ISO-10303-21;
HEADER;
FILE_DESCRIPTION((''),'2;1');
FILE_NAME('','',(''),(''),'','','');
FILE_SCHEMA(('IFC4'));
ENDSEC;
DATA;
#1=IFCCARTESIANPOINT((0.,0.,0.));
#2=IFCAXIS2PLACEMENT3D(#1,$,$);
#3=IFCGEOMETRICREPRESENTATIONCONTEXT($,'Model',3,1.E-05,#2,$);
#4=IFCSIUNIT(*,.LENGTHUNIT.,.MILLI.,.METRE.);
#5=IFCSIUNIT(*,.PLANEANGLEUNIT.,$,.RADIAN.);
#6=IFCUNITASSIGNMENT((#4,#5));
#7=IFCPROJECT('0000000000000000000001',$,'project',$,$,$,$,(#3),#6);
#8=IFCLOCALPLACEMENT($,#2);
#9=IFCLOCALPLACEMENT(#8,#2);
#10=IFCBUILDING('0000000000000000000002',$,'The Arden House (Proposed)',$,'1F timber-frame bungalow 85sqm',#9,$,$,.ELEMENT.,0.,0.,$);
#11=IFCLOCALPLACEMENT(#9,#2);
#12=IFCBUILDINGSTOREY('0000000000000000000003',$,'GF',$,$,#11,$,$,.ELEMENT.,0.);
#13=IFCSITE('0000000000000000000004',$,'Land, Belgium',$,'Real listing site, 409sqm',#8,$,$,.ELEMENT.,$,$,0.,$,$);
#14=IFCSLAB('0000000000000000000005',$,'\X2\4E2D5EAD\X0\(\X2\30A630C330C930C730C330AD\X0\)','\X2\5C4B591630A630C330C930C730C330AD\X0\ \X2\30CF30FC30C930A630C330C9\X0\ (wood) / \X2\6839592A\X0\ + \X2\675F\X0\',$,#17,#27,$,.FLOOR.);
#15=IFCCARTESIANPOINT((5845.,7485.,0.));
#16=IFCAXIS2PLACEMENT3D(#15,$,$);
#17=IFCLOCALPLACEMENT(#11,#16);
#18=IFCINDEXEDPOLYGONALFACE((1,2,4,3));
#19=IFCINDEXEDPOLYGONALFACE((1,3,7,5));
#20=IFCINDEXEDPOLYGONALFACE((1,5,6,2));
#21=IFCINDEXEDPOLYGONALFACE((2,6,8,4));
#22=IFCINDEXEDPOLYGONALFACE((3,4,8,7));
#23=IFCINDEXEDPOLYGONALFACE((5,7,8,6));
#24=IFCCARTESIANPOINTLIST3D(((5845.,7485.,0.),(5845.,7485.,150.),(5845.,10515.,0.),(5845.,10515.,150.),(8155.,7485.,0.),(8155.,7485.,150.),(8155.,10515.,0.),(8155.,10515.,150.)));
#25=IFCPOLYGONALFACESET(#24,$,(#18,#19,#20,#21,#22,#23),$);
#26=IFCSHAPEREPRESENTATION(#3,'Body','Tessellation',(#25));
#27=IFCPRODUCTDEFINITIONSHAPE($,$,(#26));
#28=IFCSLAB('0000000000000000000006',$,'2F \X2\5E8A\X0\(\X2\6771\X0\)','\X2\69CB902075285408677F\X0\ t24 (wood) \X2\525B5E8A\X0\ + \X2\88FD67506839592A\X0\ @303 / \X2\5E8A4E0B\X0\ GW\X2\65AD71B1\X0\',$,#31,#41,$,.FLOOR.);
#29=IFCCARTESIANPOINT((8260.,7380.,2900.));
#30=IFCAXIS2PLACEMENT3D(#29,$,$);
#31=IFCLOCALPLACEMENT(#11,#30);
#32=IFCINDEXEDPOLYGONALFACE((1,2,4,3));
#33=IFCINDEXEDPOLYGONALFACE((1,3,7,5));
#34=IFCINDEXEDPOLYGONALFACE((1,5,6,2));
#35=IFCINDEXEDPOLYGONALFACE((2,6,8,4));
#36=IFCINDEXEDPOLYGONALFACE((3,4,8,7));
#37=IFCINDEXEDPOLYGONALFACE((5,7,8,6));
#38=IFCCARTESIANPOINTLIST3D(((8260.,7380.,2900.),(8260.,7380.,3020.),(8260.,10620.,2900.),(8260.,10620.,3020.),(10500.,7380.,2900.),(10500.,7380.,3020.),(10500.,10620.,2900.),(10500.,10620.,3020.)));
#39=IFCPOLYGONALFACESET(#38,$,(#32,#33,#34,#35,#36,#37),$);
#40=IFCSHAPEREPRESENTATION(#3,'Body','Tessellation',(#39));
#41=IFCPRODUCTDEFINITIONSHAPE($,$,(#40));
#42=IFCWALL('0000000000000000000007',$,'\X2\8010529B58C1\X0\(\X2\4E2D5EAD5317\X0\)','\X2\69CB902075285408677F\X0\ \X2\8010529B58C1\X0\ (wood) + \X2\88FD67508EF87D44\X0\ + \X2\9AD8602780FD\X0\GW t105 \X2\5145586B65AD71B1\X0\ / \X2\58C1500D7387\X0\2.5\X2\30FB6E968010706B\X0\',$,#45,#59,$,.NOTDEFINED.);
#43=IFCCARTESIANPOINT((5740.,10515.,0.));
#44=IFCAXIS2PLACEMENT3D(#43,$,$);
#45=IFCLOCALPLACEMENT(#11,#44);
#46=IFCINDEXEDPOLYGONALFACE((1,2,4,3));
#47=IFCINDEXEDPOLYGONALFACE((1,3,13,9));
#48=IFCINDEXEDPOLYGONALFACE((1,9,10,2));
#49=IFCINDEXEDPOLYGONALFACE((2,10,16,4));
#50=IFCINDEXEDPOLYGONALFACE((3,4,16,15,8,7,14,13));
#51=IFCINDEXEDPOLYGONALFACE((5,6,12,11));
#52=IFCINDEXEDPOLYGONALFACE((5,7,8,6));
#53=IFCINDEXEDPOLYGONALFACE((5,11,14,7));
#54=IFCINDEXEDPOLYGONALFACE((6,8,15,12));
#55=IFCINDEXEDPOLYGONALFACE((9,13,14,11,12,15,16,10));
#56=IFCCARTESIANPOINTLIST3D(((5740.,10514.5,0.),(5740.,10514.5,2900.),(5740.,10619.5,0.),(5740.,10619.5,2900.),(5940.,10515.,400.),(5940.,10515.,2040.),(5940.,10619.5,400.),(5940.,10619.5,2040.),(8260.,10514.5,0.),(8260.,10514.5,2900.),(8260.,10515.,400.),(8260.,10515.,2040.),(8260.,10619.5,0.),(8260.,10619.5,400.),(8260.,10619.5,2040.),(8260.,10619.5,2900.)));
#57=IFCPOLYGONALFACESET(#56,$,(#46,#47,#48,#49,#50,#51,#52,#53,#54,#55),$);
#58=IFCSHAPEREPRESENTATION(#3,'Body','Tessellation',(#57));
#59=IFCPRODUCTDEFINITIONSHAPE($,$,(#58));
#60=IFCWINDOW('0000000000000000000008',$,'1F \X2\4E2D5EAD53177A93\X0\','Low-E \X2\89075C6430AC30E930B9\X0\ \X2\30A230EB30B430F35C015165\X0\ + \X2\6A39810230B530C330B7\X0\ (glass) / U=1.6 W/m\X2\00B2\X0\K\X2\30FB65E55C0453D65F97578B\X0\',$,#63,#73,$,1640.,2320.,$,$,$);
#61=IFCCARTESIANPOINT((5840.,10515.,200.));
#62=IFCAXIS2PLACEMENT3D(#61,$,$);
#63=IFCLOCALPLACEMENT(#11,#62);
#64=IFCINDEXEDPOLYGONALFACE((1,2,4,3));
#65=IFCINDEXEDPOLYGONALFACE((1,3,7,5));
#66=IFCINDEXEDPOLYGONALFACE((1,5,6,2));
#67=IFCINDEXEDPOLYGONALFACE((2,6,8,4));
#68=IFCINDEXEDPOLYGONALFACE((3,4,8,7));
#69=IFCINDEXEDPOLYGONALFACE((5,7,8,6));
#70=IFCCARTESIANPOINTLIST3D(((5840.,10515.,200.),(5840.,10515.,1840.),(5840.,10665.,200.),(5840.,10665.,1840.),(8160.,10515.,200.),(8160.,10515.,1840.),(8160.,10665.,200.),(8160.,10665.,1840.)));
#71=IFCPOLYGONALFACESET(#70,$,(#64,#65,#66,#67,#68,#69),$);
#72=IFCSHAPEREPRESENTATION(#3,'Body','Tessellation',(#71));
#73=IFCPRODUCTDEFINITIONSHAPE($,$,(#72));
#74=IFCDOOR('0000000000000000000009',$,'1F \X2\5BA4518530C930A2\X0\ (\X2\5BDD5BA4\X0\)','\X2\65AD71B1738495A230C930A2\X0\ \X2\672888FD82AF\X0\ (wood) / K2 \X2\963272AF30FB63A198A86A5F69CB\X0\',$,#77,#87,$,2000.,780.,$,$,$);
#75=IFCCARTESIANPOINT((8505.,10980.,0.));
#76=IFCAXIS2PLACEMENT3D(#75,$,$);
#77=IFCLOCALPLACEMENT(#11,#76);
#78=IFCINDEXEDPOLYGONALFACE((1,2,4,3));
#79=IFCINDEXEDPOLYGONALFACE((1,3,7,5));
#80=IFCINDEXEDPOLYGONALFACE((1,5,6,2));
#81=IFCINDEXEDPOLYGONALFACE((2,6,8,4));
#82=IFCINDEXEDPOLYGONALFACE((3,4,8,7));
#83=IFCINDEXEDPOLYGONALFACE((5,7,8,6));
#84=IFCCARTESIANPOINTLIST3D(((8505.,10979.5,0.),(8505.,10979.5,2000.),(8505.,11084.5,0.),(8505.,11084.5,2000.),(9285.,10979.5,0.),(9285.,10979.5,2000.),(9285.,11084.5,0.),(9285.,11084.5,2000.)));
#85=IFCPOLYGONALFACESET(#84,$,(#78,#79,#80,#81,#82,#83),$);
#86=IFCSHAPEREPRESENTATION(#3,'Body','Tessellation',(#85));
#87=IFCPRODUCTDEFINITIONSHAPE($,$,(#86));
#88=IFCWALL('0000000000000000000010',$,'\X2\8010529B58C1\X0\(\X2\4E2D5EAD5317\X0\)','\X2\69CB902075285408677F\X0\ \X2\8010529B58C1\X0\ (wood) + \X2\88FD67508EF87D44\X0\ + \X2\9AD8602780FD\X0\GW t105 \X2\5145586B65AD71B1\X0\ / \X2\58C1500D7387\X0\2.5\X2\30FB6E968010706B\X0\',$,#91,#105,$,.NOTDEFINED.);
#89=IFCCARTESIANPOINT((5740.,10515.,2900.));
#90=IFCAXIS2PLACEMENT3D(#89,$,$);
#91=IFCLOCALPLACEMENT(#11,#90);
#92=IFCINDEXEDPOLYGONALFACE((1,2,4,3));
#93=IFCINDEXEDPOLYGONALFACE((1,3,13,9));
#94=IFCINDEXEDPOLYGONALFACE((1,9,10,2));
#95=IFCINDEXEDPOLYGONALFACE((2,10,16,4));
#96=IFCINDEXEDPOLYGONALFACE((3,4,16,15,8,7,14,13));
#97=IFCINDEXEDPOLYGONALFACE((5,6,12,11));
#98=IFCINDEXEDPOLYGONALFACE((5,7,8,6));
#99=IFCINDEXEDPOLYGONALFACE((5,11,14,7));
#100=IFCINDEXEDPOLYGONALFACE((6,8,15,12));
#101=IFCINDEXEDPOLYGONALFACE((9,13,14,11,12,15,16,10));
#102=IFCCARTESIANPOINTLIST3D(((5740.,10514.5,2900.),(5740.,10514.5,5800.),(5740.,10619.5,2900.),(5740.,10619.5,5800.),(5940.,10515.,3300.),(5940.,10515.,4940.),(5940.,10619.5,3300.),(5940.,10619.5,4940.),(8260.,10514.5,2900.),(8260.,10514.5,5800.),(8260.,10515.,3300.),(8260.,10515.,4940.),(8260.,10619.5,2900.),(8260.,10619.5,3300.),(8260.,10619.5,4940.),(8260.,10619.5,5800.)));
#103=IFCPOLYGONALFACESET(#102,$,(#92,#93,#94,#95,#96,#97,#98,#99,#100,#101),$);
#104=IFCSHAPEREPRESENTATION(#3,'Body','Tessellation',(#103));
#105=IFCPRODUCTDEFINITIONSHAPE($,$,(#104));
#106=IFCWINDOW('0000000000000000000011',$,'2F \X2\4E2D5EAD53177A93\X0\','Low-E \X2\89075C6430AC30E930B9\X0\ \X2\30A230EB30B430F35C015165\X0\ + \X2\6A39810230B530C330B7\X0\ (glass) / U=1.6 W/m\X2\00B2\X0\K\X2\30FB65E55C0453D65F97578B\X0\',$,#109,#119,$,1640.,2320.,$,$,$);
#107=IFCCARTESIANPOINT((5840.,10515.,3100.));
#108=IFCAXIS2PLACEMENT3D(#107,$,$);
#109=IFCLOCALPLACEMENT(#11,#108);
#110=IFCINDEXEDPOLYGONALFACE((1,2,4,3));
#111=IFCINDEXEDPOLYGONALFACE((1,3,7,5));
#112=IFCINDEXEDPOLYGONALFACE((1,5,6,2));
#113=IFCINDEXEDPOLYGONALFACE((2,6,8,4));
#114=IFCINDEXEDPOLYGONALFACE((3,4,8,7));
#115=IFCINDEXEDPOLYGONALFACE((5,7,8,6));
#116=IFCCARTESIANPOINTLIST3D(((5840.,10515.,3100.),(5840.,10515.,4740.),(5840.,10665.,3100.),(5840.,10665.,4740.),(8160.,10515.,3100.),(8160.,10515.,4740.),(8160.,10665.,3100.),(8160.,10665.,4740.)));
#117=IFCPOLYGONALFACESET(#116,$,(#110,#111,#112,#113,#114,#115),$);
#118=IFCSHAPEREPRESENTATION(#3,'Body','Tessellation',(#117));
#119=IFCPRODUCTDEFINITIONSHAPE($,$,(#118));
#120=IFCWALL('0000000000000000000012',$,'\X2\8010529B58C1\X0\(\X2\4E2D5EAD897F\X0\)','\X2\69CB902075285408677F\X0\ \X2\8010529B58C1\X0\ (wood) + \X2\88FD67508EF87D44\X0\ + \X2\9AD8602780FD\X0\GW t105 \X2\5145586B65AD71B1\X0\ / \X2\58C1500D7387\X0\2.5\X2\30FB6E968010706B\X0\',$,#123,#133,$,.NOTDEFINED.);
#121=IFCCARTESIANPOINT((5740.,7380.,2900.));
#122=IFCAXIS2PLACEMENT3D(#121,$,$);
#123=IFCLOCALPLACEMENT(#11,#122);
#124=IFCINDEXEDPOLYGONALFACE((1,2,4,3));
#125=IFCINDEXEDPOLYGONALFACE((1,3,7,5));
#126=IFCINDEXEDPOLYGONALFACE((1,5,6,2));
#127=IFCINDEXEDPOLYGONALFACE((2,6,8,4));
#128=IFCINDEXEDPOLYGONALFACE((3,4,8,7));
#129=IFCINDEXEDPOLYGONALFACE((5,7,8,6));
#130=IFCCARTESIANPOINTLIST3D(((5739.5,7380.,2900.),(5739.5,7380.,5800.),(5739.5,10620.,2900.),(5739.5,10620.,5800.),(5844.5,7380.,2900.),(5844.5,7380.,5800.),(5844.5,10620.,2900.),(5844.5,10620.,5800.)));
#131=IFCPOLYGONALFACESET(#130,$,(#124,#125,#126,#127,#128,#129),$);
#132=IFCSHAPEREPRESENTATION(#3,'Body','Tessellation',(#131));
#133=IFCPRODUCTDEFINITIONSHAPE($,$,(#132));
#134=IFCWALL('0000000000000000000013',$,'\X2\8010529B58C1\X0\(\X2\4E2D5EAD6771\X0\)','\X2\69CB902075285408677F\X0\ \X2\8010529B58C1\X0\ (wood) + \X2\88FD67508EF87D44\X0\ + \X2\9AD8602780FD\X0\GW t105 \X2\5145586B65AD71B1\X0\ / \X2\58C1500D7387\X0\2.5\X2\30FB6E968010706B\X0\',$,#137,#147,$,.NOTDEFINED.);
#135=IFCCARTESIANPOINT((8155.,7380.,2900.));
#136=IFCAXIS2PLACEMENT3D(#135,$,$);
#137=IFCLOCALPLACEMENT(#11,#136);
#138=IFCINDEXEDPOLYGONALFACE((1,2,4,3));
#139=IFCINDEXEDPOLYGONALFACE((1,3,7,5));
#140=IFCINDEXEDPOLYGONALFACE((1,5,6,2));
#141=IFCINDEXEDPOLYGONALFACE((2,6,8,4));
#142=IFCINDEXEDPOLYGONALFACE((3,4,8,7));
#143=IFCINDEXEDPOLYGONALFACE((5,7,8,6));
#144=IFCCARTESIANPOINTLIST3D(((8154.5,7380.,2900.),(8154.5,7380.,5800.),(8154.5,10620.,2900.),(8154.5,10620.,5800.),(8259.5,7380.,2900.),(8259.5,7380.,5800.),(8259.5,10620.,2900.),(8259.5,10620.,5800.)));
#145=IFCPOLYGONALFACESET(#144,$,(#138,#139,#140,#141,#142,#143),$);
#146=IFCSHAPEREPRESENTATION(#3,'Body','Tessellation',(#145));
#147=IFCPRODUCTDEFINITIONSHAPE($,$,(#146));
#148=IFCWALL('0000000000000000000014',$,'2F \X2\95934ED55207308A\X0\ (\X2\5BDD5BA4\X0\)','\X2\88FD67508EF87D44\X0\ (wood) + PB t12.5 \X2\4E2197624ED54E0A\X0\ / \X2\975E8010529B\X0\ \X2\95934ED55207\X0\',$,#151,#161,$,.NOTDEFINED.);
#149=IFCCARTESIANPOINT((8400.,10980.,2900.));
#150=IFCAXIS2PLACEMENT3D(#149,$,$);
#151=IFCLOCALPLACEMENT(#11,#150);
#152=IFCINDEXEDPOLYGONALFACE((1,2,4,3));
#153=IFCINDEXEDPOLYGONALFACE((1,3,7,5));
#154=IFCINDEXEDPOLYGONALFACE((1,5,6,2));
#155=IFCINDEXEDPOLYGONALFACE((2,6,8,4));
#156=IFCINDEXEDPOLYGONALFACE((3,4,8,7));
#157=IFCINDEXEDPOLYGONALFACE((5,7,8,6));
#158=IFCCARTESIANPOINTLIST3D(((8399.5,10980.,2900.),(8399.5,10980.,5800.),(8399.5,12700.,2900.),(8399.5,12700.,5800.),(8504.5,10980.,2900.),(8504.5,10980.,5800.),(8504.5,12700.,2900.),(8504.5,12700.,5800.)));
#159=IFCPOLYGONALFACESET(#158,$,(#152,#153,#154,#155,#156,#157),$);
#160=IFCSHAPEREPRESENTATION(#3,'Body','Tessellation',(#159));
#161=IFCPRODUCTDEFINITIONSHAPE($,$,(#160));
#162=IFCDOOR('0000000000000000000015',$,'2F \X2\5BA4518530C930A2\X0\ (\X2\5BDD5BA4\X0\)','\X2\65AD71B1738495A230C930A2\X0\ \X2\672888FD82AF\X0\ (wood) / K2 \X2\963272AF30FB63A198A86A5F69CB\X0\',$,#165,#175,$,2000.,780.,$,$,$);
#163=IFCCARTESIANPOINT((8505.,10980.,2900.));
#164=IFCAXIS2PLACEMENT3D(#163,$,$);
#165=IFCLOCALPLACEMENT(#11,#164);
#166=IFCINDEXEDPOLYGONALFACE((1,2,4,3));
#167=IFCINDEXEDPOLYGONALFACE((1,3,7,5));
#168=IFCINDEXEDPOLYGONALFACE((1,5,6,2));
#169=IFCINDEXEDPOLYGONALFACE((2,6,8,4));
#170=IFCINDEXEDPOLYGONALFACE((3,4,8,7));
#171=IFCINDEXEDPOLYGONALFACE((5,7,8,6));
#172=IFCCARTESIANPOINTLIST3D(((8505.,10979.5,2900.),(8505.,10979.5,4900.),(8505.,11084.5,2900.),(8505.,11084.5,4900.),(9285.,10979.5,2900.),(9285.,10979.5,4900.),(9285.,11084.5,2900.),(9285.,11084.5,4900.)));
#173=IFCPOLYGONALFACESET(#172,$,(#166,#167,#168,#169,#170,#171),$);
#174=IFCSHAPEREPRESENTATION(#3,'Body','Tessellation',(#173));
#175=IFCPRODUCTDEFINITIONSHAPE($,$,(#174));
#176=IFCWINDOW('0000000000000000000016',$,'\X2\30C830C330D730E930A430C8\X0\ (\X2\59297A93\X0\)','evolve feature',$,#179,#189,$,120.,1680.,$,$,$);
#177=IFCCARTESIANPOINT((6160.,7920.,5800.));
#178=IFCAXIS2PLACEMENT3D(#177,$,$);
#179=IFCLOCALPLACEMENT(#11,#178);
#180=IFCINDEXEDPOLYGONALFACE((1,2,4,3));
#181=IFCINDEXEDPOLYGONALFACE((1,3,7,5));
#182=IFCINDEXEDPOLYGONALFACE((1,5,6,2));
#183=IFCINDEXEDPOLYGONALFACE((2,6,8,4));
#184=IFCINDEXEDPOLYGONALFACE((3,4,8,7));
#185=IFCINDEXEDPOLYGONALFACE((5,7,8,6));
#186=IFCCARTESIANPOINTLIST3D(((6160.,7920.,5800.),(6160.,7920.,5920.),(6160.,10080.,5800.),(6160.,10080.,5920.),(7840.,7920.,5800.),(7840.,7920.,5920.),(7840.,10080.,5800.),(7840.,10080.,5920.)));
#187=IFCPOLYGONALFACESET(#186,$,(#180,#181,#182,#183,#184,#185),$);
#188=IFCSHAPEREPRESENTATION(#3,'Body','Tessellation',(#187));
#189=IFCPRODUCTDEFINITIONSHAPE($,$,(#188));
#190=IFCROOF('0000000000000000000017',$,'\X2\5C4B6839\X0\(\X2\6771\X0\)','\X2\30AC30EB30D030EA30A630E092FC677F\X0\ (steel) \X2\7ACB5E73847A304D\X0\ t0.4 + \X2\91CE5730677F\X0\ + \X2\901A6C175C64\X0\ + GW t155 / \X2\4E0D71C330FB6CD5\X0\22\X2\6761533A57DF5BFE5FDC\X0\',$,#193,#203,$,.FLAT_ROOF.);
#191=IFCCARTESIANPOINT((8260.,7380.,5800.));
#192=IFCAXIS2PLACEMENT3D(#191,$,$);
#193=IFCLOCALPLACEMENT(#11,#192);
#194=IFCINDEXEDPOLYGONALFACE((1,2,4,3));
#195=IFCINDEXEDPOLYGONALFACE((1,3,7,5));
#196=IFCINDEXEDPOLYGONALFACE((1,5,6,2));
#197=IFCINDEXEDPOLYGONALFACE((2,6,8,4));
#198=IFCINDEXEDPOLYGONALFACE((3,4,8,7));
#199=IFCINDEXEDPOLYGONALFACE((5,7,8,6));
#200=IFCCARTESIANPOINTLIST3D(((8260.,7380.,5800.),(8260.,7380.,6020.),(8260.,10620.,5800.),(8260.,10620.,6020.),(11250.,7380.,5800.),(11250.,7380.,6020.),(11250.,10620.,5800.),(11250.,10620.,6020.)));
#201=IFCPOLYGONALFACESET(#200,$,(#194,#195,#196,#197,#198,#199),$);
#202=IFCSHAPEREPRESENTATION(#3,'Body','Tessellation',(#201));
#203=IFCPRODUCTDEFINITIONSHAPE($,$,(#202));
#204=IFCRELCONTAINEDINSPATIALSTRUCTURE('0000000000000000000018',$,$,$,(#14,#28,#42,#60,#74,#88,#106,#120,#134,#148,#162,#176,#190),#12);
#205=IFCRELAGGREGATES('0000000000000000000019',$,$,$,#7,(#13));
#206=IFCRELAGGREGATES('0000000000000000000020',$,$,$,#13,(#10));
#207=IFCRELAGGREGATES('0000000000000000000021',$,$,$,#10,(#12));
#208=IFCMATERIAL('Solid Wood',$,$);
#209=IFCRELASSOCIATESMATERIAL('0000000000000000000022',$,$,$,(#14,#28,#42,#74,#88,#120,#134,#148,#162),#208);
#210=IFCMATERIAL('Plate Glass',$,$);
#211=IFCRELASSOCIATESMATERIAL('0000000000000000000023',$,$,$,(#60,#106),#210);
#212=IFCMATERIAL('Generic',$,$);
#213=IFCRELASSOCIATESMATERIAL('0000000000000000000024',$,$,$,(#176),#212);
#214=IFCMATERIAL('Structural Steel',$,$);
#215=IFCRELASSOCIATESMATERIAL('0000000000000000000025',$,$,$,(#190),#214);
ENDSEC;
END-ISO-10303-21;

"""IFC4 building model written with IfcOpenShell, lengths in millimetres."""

from ifc_helpers import new_model, si_unit, frame, frame_2d, origin, place, context, project, spatial, rectangle, extrude, material, element, fill, save


model = new_model("IFC4")

# Units and contexts
model_context = context("Model", 3, precision=1e-05, world=origin())
ifc_project = project(units=[si_unit("LENGTHUNIT", "METRE", prefix="MILLI"), si_unit("PLANEANGLEUNIT", "RADIAN")], contexts=[model_context])

# Site, building, storey
site_placement = place(None, origin())
site = spatial("IfcSite", under=ifc_project, at=site_placement, Name="Land, Belgium", ObjectType="Real listing site, 409sqm", CompositionType="ELEMENT", RefElevation=0.0)
building_placement = place(site_placement, origin())
building = spatial("IfcBuilding", under=site, at=building_placement, Name="The Arden House (Proposed)", ObjectType="1F timber-frame bungalow 85sqm", CompositionType="ELEMENT", ElevationOfRefHeight=0.0, ElevationOfTerrain=0.0)
storey_placement = place(building_placement, origin())
storey = spatial("IfcBuildingStorey", under=building, at=storey_placement, Name="GF", CompositionType="ELEMENT", Elevation=0.0)

# Slabs
ifc_material_1 = material(Name="Solid Wood")
slab_1_placement = place(storey_placement, frame((5845.0, 7485.0, 0.0)))
element("IfcSlab", 1, at=slab_1_placement, inside=storey, material=ifc_material_1, Name="中庭(ウッドデッキ)", Description="屋外ウッドデッキ ハードウッド (wood) / 根太 + 束", PredefinedType="FLOOR", context=model_context, shape_type="SweptSolid", body=[
    extrude(rectangle(XDim=2310.0, YDim=3030.0, at=frame_2d((1155.0, 1515.0))), frame((5845.0, 7485.0, 0.0)), (0.0, 0.0, 1.0), 150.0),
])
slab_2_placement = place(storey_placement, frame((8260.0, 7380.0, 2900.0)))
element("IfcSlab", 2, at=slab_2_placement, inside=storey, material=ifc_material_1, Name="2F 床(東)", Description="構造用合板 t24 (wood) 剛床 + 製材根太 @303 / 床下 GW断熱", PredefinedType="FLOOR", context=model_context, shape_type="SweptSolid", body=[
    extrude(rectangle(XDim=2240.0, YDim=3240.0, at=frame_2d((1120.0, 1620.0))), frame((8260.0, 7380.0, 2900.0)), (0.0, 0.0, 1.0), 120.0),
])

# Wall, opening, window
wall_1_placement = place(storey_placement, frame((5740.0, 10515.0, 0.0)))
wall_1 = element("IfcWall", 3, at=wall_1_placement, inside=storey, material=ifc_material_1, Name="耐力壁(中庭北)", Description="構造用合板 耐力壁 (wood) + 製材軸組 + 高性能GW t105 充填断熱 / 壁倍率2.5・準耐火", PredefinedType="NOTDEFINED", context=model_context, shape_type="SweptSolid", body=[
    extrude(rectangle(XDim=2520.0, YDim=105.0, at=frame_2d((1260.0, 52.0))), frame((5740.0, 10515.0, 0.0)), (0.0, 0.0, 1.0), 2900.0),
])
opening_1_placement = place(storey_placement, frame((5840.0, 10515.0, 200.0)))
opening_1 = element("IfcOpeningElement", 4, at=opening_1_placement, cuts=wall_1, PredefinedType="NOTDEFINED", context=model_context, shape_type="SweptSolid", body=[
    extrude(rectangle(XDim=2320.0, YDim=150.0, at=frame_2d((1160.0, 75.0))), frame((5840.0, 10515.0, 200.0)), (0.0, 0.0, 1.0), 1640.0),
])
ifc_material_2 = material(Name="Plate Glass")
window_1_placement = place(storey_placement, frame((5840.0, 10515.0, 200.0)))
window_1 = element("IfcWindow", 5, at=window_1_placement, inside=storey, material=ifc_material_2, Name="1F 中庭北窓", Description="Low-E 複層ガラス アルゴン封入 + 樹脂サッシ (glass) / U=1.6 W/m²K・日射取得型", OverallHeight=1640.0, OverallWidth=2320.0, context=model_context, shape_type="SweptSolid", body=[
    extrude(rectangle(XDim=2320.0, YDim=150.0, at=frame_2d((1160.0, 75.0))), frame((5840.0, 10515.0, 200.0)), (0.0, 0.0, 1.0), 1640.0),
])
fill(opening_1, window_1)

# Door
door_1_placement = place(storey_placement, frame((8505.0, 10980.0, 0.0)))
element("IfcDoor", 6, at=door_1_placement, inside=storey, material=ifc_material_1, Name="1F 室内ドア (寝室)", Description="断熱玄関ドア 木製芯 (wood) / K2 防犯・採風機構", OverallHeight=2000.0, OverallWidth=780.0, context=model_context, shape_type="SweptSolid", body=[
    extrude(rectangle(XDim=780.0, YDim=105.0, at=frame_2d((390.0, 52.0))), frame((8505.0, 10980.0, 0.0)), (0.0, 0.0, 1.0), 2000.0),
])

# Wall, opening, window
wall_2_placement = place(storey_placement, frame((5740.0, 10515.0, 2900.0)))
wall_2 = element("IfcWall", 7, at=wall_2_placement, inside=storey, material=ifc_material_1, Name="耐力壁(中庭北)", Description="構造用合板 耐力壁 (wood) + 製材軸組 + 高性能GW t105 充填断熱 / 壁倍率2.5・準耐火", PredefinedType="NOTDEFINED", context=model_context, shape_type="SweptSolid", body=[
    extrude(rectangle(XDim=2520.0, YDim=105.0, at=frame_2d((1260.0, 52.0))), frame((5740.0, 10515.0, 2900.0)), (0.0, 0.0, 1.0), 2900.0),
])
opening_2_placement = place(storey_placement, frame((5840.0, 10515.0, 3100.0)))
opening_2 = element("IfcOpeningElement", 8, at=opening_2_placement, cuts=wall_2, PredefinedType="NOTDEFINED", context=model_context, shape_type="SweptSolid", body=[
    extrude(rectangle(XDim=2320.0, YDim=150.0, at=frame_2d((1160.0, 75.0))), frame((5840.0, 10515.0, 3100.0)), (0.0, 0.0, 1.0), 1640.0),
])
window_2_placement = place(storey_placement, frame((5840.0, 10515.0, 3100.0)))
window_2 = element("IfcWindow", 9, at=window_2_placement, inside=storey, material=ifc_material_2, Name="2F 中庭北窓", Description="Low-E 複層ガラス アルゴン封入 + 樹脂サッシ (glass) / U=1.6 W/m²K・日射取得型", OverallHeight=1640.0, OverallWidth=2320.0, context=model_context, shape_type="SweptSolid", body=[
    extrude(rectangle(XDim=2320.0, YDim=150.0, at=frame_2d((1160.0, 75.0))), frame((5840.0, 10515.0, 3100.0)), (0.0, 0.0, 1.0), 1640.0),
])
fill(opening_2, window_2)

# Walls
wall_3_placement = place(storey_placement, frame((5740.0, 7380.0, 2900.0)))
element("IfcWall", 10, at=wall_3_placement, inside=storey, material=ifc_material_1, Name="耐力壁(中庭西)", Description="構造用合板 耐力壁 (wood) + 製材軸組 + 高性能GW t105 充填断熱 / 壁倍率2.5・準耐火", PredefinedType="NOTDEFINED", context=model_context, shape_type="SweptSolid", body=[
    extrude(rectangle(XDim=105.0, YDim=3240.0, at=frame_2d((52.0, 1620.0))), frame((5740.0, 7380.0, 2900.0)), (0.0, 0.0, 1.0), 2900.0),
])
wall_4_placement = place(storey_placement, frame((8155.0, 7380.0, 2900.0)))
element("IfcWall", 11, at=wall_4_placement, inside=storey, material=ifc_material_1, Name="耐力壁(中庭東)", Description="構造用合板 耐力壁 (wood) + 製材軸組 + 高性能GW t105 充填断熱 / 壁倍率2.5・準耐火", PredefinedType="NOTDEFINED", context=model_context, shape_type="SweptSolid", body=[
    extrude(rectangle(XDim=105.0, YDim=3240.0, at=frame_2d((52.0, 1620.0))), frame((8155.0, 7380.0, 2900.0)), (0.0, 0.0, 1.0), 2900.0),
])
wall_5_placement = place(storey_placement, frame((8400.0, 10980.0, 2900.0)))
element("IfcWall", 12, at=wall_5_placement, inside=storey, material=ifc_material_1, Name="2F 間仕切り (寝室)", Description="製材軸組 (wood) + PB t12.5 両面仕上 / 非耐力 間仕切", PredefinedType="NOTDEFINED", context=model_context, shape_type="SweptSolid", body=[
    extrude(rectangle(XDim=105.0, YDim=1720.0, at=frame_2d((52.0, 860.0))), frame((8400.0, 10980.0, 2900.0)), (0.0, 0.0, 1.0), 2900.0),
])

# Door
door_2_placement = place(storey_placement, frame((8505.0, 10980.0, 2900.0)))
element("IfcDoor", 13, at=door_2_placement, inside=storey, material=ifc_material_1, Name="2F 室内ドア (寝室)", Description="断熱玄関ドア 木製芯 (wood) / K2 防犯・採風機構", OverallHeight=2000.0, OverallWidth=780.0, context=model_context, shape_type="SweptSolid", body=[
    extrude(rectangle(XDim=780.0, YDim=105.0, at=frame_2d((390.0, 52.0))), frame((8505.0, 10980.0, 2900.0)), (0.0, 0.0, 1.0), 2000.0),
])

# Window
ifc_material_3 = material(Name="Generic")
window_3_placement = place(storey_placement, frame((6160.0, 7920.0, 5800.0)))
element("IfcWindow", 14, at=window_3_placement, inside=storey, material=ifc_material_3, Name="トップライト (天窓)", Description="evolve feature", OverallHeight=120.0, OverallWidth=1680.0, context=model_context, shape_type="SweptSolid", body=[
    extrude(rectangle(XDim=1680.0, YDim=2160.0, at=frame_2d((840.0, 1080.0))), frame((6160.0, 7920.0, 5800.0)), (0.0, 0.0, 1.0), 120.0),
])

# Roof
ifc_material_4 = material(Name="Structural Steel")
roof_placement = place(storey_placement, frame((8260.0, 7380.0, 5800.0)))
element("IfcRoof", 15, at=roof_placement, inside=storey, material=ifc_material_4, Name="屋根(東)", Description="ガルバリウム鋼板 (steel) 立平葺き t0.4 + 野地板 + 通気層 + GW t155 / 不燃・法22条区域対応", PredefinedType="FLAT_ROOF", context=model_context, shape_type="SweptSolid", body=[
    extrude(rectangle(XDim=2990.0, YDim=3240.0, at=frame_2d((1495.0, 1620.0))), frame((8260.0, 7380.0, 5800.0)), (0.0, 0.0, 1.0), 220.0),
])

save(model, "model.ifc")
